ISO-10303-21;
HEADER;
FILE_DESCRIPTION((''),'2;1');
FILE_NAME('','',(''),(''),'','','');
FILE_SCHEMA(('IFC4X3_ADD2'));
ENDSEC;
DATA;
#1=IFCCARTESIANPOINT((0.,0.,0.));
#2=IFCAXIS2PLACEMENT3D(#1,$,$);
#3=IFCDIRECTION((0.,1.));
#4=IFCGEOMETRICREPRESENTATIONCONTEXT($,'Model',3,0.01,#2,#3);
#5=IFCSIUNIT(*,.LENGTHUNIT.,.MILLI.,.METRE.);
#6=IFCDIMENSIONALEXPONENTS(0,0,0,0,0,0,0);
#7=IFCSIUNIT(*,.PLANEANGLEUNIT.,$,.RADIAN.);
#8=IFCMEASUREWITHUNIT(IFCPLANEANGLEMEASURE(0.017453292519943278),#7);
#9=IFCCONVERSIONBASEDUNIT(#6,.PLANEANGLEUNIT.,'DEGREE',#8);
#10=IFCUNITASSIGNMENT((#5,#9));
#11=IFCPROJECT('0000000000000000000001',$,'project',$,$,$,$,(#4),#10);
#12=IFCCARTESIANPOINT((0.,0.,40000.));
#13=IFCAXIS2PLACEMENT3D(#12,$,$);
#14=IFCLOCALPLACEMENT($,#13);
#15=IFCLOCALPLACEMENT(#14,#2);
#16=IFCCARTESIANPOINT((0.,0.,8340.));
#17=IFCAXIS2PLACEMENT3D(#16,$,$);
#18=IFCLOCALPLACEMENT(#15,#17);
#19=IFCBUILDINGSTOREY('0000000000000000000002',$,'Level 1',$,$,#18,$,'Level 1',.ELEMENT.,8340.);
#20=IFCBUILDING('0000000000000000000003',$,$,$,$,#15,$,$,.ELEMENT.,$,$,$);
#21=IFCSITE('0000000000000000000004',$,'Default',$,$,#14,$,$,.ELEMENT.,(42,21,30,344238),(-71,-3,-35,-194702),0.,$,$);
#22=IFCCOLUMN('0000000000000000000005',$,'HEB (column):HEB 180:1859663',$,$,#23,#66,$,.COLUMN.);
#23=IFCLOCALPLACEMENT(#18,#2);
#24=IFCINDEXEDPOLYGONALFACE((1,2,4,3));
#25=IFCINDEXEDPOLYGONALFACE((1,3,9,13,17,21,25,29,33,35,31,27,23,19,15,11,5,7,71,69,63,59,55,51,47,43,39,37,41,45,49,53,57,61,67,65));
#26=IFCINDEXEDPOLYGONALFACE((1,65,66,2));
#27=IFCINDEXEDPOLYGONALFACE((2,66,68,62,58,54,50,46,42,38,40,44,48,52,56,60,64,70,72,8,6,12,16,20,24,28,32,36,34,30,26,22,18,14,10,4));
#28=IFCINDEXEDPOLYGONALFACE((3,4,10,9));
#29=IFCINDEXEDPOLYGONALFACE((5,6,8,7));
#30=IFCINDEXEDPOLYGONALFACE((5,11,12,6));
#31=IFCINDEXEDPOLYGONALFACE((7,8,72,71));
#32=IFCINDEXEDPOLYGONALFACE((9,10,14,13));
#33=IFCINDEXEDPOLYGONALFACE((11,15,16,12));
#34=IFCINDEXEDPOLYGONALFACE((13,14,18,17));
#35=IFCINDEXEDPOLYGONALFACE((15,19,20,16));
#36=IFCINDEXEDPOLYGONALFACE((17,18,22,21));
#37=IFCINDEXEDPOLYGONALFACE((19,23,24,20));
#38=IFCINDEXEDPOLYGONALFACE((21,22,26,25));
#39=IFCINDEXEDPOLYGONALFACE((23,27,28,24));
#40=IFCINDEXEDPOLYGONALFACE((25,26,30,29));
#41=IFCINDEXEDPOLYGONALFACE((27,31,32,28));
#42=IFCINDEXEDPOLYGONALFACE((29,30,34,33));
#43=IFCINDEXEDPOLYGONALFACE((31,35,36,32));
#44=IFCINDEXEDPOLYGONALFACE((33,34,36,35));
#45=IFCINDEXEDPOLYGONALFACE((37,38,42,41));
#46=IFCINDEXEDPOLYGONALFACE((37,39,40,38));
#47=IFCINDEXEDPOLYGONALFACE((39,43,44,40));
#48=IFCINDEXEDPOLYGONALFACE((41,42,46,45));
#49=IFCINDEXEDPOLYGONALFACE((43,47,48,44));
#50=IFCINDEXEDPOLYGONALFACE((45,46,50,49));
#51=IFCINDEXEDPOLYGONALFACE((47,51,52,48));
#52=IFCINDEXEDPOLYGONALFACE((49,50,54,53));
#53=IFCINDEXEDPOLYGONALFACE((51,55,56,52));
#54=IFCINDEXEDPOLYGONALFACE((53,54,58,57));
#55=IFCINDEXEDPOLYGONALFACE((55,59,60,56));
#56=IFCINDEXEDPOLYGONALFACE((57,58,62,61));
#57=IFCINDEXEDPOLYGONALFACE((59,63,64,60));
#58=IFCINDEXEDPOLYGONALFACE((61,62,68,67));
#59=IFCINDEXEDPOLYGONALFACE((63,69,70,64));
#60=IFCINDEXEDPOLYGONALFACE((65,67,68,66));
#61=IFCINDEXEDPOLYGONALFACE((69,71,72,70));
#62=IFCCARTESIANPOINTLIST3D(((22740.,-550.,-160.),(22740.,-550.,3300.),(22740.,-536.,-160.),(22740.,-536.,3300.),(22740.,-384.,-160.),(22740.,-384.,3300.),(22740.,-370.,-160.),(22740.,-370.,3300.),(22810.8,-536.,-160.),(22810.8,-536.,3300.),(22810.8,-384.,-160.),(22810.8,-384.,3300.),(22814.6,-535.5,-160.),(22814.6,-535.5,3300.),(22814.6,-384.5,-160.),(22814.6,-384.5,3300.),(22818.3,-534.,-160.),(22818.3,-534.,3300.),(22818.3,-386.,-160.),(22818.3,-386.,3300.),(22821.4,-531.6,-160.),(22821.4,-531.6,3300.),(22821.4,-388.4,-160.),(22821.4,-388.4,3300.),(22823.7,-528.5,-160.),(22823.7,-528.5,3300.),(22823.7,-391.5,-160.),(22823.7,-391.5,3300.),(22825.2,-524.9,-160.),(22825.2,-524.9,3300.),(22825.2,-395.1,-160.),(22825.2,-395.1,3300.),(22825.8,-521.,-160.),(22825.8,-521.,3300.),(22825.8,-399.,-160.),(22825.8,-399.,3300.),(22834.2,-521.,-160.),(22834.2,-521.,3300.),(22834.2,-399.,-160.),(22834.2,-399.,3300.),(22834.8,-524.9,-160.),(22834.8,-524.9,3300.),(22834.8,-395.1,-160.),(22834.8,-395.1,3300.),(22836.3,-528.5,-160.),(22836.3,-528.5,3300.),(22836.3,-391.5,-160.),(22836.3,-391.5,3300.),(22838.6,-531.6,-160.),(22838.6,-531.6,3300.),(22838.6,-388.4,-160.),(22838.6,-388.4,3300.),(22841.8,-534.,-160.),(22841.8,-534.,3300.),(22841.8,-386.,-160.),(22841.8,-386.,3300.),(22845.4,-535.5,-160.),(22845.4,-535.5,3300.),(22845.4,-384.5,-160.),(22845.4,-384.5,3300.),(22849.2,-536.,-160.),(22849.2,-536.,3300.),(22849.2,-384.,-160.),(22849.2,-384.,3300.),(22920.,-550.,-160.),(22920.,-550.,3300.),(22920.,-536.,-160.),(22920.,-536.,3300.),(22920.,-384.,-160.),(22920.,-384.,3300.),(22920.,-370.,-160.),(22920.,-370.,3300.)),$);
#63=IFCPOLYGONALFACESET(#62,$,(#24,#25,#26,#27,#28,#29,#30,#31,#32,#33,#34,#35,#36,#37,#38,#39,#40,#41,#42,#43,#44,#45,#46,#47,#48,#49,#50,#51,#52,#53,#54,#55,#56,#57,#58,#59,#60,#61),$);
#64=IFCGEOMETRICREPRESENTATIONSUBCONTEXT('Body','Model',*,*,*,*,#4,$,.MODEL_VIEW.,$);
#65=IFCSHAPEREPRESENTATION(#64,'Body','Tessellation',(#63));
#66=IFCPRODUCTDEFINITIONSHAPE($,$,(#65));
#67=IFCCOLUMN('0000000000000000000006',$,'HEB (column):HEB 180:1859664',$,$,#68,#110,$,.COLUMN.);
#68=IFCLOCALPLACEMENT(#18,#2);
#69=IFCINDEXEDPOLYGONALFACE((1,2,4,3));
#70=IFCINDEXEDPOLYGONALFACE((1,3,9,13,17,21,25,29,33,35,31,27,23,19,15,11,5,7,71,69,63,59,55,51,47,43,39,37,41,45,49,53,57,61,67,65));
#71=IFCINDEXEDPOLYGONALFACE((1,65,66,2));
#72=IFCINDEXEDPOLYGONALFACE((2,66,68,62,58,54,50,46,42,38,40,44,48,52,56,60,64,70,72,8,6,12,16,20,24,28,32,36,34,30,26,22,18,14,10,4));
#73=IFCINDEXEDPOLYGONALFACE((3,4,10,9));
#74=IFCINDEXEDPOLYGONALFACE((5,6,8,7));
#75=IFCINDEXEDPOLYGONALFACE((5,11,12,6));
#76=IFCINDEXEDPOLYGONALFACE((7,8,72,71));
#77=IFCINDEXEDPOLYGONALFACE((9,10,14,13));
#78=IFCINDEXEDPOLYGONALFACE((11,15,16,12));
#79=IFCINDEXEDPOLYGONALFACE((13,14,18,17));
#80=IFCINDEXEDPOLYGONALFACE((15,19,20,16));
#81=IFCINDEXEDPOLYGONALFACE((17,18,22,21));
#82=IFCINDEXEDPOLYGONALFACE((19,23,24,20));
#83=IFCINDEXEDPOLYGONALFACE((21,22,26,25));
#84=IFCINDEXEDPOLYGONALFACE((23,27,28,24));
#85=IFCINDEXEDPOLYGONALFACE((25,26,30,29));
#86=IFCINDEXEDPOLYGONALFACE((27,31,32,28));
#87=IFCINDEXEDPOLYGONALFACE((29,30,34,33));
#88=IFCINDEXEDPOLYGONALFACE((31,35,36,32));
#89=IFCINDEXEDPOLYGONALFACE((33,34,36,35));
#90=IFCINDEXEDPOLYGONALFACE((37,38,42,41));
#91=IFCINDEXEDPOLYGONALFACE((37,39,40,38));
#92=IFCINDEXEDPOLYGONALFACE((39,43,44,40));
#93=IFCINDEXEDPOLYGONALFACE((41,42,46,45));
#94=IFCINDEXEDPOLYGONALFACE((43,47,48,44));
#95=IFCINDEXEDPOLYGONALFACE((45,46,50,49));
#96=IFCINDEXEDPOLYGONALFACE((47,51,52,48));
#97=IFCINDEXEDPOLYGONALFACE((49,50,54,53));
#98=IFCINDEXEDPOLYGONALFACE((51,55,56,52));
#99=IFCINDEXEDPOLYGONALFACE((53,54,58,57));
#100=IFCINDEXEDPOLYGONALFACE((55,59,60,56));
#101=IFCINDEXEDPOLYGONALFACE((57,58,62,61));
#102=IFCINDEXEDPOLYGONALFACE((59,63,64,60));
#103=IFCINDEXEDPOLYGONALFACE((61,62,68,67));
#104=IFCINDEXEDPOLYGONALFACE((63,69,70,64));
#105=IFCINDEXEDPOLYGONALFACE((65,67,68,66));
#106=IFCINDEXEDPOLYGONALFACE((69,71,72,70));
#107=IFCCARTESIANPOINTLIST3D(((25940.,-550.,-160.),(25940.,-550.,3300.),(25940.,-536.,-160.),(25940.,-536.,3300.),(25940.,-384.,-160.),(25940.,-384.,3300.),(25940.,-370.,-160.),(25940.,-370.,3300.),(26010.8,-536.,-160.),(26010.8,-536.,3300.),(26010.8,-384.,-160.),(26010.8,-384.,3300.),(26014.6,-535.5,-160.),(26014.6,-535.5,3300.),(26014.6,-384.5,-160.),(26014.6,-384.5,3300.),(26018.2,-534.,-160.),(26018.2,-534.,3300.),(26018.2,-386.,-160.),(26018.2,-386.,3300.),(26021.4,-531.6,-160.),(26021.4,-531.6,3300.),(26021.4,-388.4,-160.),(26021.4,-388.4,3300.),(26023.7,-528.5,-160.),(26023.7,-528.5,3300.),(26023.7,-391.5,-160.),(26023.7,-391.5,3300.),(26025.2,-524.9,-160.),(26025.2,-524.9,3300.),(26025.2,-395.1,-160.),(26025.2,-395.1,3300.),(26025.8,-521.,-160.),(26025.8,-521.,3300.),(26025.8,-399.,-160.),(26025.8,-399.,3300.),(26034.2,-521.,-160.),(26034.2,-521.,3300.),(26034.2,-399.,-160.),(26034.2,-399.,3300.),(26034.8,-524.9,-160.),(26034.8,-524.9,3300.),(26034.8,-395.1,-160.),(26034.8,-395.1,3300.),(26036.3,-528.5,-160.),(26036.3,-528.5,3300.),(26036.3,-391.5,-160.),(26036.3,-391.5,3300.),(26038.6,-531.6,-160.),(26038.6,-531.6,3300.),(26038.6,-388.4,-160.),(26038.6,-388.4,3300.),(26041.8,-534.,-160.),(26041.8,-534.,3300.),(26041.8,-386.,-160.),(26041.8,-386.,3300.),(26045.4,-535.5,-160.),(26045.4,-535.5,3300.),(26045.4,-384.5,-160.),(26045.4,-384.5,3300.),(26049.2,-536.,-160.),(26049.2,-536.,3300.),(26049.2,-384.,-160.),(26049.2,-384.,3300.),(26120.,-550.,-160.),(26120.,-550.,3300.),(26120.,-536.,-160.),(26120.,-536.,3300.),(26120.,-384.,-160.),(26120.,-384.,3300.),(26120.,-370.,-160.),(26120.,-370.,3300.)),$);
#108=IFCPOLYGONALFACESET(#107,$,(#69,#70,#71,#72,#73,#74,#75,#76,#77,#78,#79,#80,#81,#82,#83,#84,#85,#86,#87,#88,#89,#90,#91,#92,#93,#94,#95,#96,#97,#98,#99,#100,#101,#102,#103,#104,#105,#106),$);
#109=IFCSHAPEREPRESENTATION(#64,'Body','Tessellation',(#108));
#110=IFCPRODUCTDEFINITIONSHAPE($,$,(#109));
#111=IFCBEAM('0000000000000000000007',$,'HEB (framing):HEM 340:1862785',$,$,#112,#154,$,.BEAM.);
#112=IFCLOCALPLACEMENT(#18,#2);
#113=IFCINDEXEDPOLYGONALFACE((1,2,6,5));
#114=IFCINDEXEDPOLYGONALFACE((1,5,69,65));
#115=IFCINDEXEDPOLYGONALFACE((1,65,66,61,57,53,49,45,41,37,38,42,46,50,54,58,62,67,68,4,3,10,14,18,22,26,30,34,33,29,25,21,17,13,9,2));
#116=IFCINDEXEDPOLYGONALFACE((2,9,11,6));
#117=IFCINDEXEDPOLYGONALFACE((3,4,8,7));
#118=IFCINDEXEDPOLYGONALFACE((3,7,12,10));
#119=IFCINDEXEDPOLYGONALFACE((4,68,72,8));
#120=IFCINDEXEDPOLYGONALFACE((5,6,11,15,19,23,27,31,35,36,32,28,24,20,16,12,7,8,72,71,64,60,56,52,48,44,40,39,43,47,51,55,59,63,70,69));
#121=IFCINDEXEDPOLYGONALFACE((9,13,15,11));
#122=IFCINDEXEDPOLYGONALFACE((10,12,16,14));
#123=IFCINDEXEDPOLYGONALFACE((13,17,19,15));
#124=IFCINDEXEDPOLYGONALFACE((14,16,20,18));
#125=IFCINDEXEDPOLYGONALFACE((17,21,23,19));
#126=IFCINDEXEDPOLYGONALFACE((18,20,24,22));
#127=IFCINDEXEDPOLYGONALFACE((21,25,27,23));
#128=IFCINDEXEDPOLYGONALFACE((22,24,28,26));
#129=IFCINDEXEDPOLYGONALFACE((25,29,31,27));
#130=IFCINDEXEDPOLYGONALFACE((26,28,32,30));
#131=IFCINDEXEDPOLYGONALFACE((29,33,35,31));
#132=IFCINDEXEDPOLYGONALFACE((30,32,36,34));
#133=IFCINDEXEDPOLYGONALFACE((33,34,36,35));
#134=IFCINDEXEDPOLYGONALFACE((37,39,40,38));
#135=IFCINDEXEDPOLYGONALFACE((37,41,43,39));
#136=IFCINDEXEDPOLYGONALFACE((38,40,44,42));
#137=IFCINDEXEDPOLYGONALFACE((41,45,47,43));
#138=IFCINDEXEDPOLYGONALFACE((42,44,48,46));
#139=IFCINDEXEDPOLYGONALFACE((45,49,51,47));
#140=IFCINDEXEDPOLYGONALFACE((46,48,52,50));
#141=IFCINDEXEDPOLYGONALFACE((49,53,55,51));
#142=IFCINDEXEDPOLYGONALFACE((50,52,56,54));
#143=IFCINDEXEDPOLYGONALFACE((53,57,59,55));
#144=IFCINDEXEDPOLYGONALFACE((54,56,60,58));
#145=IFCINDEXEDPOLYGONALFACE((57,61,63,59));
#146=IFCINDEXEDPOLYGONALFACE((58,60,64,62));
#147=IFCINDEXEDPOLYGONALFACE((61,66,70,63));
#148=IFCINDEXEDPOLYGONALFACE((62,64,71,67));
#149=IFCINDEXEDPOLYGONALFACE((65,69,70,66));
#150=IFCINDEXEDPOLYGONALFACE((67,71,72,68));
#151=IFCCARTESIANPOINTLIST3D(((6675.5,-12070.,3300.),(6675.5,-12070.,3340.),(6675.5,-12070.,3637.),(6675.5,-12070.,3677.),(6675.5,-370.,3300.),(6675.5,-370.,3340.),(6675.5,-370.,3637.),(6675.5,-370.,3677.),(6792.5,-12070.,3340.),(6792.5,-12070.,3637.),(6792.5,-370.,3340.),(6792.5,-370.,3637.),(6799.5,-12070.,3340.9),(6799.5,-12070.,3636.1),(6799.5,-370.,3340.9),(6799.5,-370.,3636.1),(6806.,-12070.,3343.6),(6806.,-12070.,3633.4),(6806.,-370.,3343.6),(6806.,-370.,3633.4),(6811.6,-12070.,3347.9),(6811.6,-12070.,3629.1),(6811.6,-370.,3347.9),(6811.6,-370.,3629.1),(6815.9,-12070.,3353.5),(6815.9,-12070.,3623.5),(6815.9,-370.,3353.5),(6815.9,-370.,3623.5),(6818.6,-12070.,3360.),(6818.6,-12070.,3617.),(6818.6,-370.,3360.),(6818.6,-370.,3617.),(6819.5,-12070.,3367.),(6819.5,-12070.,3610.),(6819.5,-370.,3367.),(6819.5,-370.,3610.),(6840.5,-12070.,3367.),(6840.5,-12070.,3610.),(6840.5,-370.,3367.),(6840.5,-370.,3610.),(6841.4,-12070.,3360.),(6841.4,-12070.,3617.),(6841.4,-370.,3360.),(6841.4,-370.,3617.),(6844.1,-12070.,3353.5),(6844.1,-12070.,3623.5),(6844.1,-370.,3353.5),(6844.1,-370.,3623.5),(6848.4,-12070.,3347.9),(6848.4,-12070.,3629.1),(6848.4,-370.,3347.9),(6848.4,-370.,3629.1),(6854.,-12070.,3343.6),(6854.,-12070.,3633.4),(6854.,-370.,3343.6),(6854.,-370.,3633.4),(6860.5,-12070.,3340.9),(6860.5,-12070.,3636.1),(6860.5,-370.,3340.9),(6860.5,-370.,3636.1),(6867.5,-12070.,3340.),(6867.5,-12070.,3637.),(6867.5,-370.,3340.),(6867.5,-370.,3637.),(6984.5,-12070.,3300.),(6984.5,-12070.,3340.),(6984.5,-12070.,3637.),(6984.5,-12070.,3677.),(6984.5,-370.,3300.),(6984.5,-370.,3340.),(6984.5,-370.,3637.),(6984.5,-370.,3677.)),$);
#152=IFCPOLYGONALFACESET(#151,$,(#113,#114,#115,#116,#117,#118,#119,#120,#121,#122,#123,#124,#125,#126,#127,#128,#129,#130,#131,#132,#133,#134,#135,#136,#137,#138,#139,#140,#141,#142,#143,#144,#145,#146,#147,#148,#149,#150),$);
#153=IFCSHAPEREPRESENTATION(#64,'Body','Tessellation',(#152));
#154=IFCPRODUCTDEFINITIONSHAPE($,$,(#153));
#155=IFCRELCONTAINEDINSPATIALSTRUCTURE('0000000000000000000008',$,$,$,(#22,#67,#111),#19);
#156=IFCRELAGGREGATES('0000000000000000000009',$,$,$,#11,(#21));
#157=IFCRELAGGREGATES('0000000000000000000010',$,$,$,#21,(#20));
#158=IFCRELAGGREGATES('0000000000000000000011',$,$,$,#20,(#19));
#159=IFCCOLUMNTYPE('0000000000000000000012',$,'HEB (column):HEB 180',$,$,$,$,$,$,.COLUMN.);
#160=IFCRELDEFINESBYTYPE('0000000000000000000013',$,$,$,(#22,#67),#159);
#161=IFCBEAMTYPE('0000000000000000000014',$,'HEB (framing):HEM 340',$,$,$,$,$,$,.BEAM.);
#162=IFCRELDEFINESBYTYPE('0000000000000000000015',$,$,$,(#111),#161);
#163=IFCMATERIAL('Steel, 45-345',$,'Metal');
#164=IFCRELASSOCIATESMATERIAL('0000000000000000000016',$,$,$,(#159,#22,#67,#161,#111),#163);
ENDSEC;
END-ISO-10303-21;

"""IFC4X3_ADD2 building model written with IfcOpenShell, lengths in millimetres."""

from ifc_helpers import new_model, entity, si_unit, converted_unit, direction, frame, frame_2d, origin, origin_2d_with_axis, place, context, subcontext, project, spatial, polyline, circle_curve, parameter, trimmed, segment, composite_curve, i_section, outline, extrude, source, transform, mapped, material, material_profile, profile_set, profile_usage, type_object, type_shapes, element, save


model = new_model("IFC4X3_ADD2")

# Units and contexts
model_context = context("Model", 3, precision=0.01, world=origin(), true_north=direction((0.0, 1.0)))
body_context = subcontext(model_context, "Body", "Model", "MODEL_VIEW")
ifc_project = project(units=[si_unit("LENGTHUNIT", "METRE", prefix="MILLI"), converted_unit("PLANEANGLEUNIT", "DEGREE", entity("IfcPlaneAngleMeasure", 0.017453292519943278), si_unit("PLANEANGLEUNIT", "RADIAN"), dimensions=[0, 0, 0, 0, 0, 0, 0])], contexts=[model_context])

# Site, building, storey
site_placement = place(None, frame((0.0, 0.0, 40000.0)))
site = spatial("IfcSite", under=ifc_project, at=site_placement, Name="Default", CompositionType="ELEMENT", RefLatitude=(42, 21, 30, 344238), RefLongitude=(-71, -3, -35, -194702), RefElevation=0.0)
building_placement = place(site_placement, origin())
building = spatial("IfcBuilding", under=site, at=building_placement, CompositionType="ELEMENT")
storey_placement = place(building_placement, frame((0.0, 0.0, 8340.0)))
storey = spatial("IfcBuildingStorey", under=building, at=storey_placement, Name="Level 1", LongName="Level 1", CompositionType="ELEMENT", Elevation=8340.0)

# Columns
ifc_material_1 = material(Name="Steel, 45-345", Category="Metal")
ifc_material_profile_1 = material_profile(ifc_material_1, i_section(OverallWidth=180.0, OverallDepth=180.0, WebThickness=8.5, FlangeThickness=14.0, FilletRadius=15.0, at=origin_2d_with_axis()), Name="HEB 180")
ifc_profile_set_1 = profile_set([ifc_material_profile_1], Name="HEB 180")
ifc_profile_usage_1 = profile_usage(ifc_profile_set_1)
column_type = type_object("IfcColumnType", Name="HEB (column):HEB 180", PredefinedType="COLUMN", material=ifc_profile_set_1)
shared_shape_1 = source(origin(), body_context, "Body", "SweptSolid", [
    extrude(i_section(OverallWidth=180.0, OverallDepth=180.0, WebThickness=8.5, FlangeThickness=14.0, FilletRadius=15.0, at=origin_2d_with_axis()), frame((0.0, 0.0, 8180.0), z_axis=(0.0, 0.0, 1.0), x_axis=(-1.0, 0.0, 0.0)), (0.0, 0.0, 1.0), 3460.0),
])
type_shapes(column_type, [shared_shape_1])
for number, where, name in (
    (1, (22830.0, -460.0, -8340.0), "HEB (column):HEB 180:1859663"),
    (2, (26030.0, -460.0, -8340.0), "HEB (column):HEB 180:1859664"),
):
    element("IfcColumn", number, at=place(storey_placement, frame(where)), inside=storey, type_object=column_type, material=ifc_profile_usage_1, Name=name, PredefinedType="COLUMN", context=body_context, shape_type="MappedRepresentation", body=[
        mapped(shared_shape_1, transform((0.0, 0.0, 0.0), scale=1.0)),
    ])

# Beam
ifc_material_profile_2 = material_profile(ifc_material_1, outline(composite_curve([segment(polyline([(-154.5, -148.5), (-154.5, -188.5)]), True, "CONTINUOUS"), segment(polyline([(-154.5, -188.5), (154.5, -188.5)]), True, "CONTINUOUS"), segment(polyline([(154.5, -188.5), (154.5, -148.5)]), True, "CONTINUOUS"), segment(polyline([(154.5, -148.5), (37.5, -148.5)]), True, "CONTINUOUS"), segment(trimmed(circle_curve(frame_2d((37.5, -121.5), x_axis=(1.0, 0.0)), 27.0), [parameter(180.0)], [parameter(270.0)], True, "PARAMETER"), False, "CONTINUOUS"), segment(polyline([(10.5, -121.5), (10.5, 121.5)]), True, "CONTINUOUS"), segment(trimmed(circle_curve(frame_2d((37.5, 121.5), x_axis=(1.0, 0.0)), 27.0), [parameter(90.0)], [parameter(180.0)], True, "PARAMETER"), False, "CONTINUOUS"), segment(polyline([(37.5, 148.5), (154.5, 148.5)]), True, "CONTINUOUS"), segment(polyline([(154.5, 148.5), (154.5, 188.5)]), True, "CONTINUOUS"), segment(polyline([(154.5, 188.5), (-154.5, 188.5)]), True, "CONTINUOUS"), segment(polyline([(-154.5, 188.5), (-154.5, 148.5)]), True, "CONTINUOUS"), segment(polyline([(-154.5, 148.5), (-37.5, 148.5)]), True, "CONTINUOUS"), segment(trimmed(circle_curve(frame_2d((-37.5, 121.5), x_axis=(1.0, 0.0)), 27.0), [parameter(360.0)], [parameter(90.0)], True, "PARAMETER"), False, "CONTINUOUS"), segment(polyline([(-10.5, 121.5), (-10.5, -121.5)]), True, "CONTINUOUS"), segment(trimmed(circle_curve(frame_2d((-37.5, -121.5), x_axis=(1.0, 0.0)), 27.0), [parameter(270.0)], [parameter(0.0)], True, "PARAMETER"), False, "CONTINUOUS"), segment(polyline([(-37.5, -148.5), (-154.5, -148.5)]), True, "CONTINUOUS")], self_intersect=False)), Name="HEM 340")
ifc_profile_set_2 = profile_set([ifc_material_profile_2], Name="HEM 340")
ifc_profile_usage_2 = profile_usage(ifc_profile_set_2, cardinal=8)
beam_type_1 = type_object("IfcBeamType", Name="HEB (framing):HEM 340", PredefinedType="BEAM", material=ifc_profile_set_2)
shared_shape_2 = source(origin(), body_context, "Body", "SweptSolid", [
    extrude(outline(composite_curve([segment(polyline([(-154.5, -148.5), (-154.5, -188.5)]), True, "CONTINUOUS"), segment(polyline([(-154.5, -188.5), (154.5, -188.5)]), True, "CONTINUOUS"), segment(polyline([(154.5, -188.5), (154.5, -148.5)]), True, "CONTINUOUS"), segment(polyline([(154.5, -148.5), (37.5, -148.5)]), True, "CONTINUOUS"), segment(trimmed(circle_curve(frame_2d((37.5, -121.5), x_axis=(1.0, 0.0)), 27.0), [parameter(180.0)], [parameter(270.0)], True, "PARAMETER"), False, "CONTINUOUS"), segment(polyline([(10.5, -121.5), (10.5, 121.5)]), True, "CONTINUOUS"), segment(trimmed(circle_curve(frame_2d((37.5, 121.5), x_axis=(1.0, 0.0)), 27.0), [parameter(90.0)], [parameter(180.0)], True, "PARAMETER"), False, "CONTINUOUS"), segment(polyline([(37.5, 148.5), (154.5, 148.5)]), True, "CONTINUOUS"), segment(polyline([(154.5, 148.5), (154.5, 188.5)]), True, "CONTINUOUS"), segment(polyline([(154.5, 188.5), (-154.5, 188.5)]), True, "CONTINUOUS"), segment(polyline([(-154.5, 188.5), (-154.5, 148.5)]), True, "CONTINUOUS"), segment(polyline([(-154.5, 148.5), (-37.5, 148.5)]), True, "CONTINUOUS"), segment(trimmed(circle_curve(frame_2d((-37.5, 121.5), x_axis=(1.0, 0.0)), 27.0), [parameter(360.0)], [parameter(90.0)], True, "PARAMETER"), False, "CONTINUOUS"), segment(polyline([(-10.5, 121.5), (-10.5, -121.5)]), True, "CONTINUOUS"), segment(trimmed(circle_curve(frame_2d((-37.5, -121.5), x_axis=(1.0, 0.0)), 27.0), [parameter(270.0)], [parameter(0.0)], True, "PARAMETER"), False, "CONTINUOUS"), segment(polyline([(-37.5, -148.5), (-154.5, -148.5)]), True, "CONTINUOUS")], self_intersect=False)), frame((-5850.0, 0.0, 0.0), z_axis=(-1.0, 0.0, 0.0), x_axis=(0.0, -1.0, 0.0)), (0.0, 0.0, -1.0), 11700.0),
])
type_shapes(beam_type_1, [shared_shape_2])
for number, where, z_axis, x_axis, name in (
    (3, (6830.0, -6220.0, 3488.5), (0.0, 0.0, 1.0), (0.0, -1.0, 0.0), "HEB (framing):HEM 340:1862785"),
):
    element("IfcBeam", number, at=place(storey_placement, frame(where, z_axis=z_axis, x_axis=x_axis)), inside=storey, type_object=beam_type_1, material=ifc_profile_usage_2, Name=name, PredefinedType="BEAM", context=body_context, shape_type="MappedRepresentation", body=[
        mapped(shared_shape_2, transform((0.0, 0.0, 0.0), scale=1.0)),
    ])

save(model, "model.ifc")
